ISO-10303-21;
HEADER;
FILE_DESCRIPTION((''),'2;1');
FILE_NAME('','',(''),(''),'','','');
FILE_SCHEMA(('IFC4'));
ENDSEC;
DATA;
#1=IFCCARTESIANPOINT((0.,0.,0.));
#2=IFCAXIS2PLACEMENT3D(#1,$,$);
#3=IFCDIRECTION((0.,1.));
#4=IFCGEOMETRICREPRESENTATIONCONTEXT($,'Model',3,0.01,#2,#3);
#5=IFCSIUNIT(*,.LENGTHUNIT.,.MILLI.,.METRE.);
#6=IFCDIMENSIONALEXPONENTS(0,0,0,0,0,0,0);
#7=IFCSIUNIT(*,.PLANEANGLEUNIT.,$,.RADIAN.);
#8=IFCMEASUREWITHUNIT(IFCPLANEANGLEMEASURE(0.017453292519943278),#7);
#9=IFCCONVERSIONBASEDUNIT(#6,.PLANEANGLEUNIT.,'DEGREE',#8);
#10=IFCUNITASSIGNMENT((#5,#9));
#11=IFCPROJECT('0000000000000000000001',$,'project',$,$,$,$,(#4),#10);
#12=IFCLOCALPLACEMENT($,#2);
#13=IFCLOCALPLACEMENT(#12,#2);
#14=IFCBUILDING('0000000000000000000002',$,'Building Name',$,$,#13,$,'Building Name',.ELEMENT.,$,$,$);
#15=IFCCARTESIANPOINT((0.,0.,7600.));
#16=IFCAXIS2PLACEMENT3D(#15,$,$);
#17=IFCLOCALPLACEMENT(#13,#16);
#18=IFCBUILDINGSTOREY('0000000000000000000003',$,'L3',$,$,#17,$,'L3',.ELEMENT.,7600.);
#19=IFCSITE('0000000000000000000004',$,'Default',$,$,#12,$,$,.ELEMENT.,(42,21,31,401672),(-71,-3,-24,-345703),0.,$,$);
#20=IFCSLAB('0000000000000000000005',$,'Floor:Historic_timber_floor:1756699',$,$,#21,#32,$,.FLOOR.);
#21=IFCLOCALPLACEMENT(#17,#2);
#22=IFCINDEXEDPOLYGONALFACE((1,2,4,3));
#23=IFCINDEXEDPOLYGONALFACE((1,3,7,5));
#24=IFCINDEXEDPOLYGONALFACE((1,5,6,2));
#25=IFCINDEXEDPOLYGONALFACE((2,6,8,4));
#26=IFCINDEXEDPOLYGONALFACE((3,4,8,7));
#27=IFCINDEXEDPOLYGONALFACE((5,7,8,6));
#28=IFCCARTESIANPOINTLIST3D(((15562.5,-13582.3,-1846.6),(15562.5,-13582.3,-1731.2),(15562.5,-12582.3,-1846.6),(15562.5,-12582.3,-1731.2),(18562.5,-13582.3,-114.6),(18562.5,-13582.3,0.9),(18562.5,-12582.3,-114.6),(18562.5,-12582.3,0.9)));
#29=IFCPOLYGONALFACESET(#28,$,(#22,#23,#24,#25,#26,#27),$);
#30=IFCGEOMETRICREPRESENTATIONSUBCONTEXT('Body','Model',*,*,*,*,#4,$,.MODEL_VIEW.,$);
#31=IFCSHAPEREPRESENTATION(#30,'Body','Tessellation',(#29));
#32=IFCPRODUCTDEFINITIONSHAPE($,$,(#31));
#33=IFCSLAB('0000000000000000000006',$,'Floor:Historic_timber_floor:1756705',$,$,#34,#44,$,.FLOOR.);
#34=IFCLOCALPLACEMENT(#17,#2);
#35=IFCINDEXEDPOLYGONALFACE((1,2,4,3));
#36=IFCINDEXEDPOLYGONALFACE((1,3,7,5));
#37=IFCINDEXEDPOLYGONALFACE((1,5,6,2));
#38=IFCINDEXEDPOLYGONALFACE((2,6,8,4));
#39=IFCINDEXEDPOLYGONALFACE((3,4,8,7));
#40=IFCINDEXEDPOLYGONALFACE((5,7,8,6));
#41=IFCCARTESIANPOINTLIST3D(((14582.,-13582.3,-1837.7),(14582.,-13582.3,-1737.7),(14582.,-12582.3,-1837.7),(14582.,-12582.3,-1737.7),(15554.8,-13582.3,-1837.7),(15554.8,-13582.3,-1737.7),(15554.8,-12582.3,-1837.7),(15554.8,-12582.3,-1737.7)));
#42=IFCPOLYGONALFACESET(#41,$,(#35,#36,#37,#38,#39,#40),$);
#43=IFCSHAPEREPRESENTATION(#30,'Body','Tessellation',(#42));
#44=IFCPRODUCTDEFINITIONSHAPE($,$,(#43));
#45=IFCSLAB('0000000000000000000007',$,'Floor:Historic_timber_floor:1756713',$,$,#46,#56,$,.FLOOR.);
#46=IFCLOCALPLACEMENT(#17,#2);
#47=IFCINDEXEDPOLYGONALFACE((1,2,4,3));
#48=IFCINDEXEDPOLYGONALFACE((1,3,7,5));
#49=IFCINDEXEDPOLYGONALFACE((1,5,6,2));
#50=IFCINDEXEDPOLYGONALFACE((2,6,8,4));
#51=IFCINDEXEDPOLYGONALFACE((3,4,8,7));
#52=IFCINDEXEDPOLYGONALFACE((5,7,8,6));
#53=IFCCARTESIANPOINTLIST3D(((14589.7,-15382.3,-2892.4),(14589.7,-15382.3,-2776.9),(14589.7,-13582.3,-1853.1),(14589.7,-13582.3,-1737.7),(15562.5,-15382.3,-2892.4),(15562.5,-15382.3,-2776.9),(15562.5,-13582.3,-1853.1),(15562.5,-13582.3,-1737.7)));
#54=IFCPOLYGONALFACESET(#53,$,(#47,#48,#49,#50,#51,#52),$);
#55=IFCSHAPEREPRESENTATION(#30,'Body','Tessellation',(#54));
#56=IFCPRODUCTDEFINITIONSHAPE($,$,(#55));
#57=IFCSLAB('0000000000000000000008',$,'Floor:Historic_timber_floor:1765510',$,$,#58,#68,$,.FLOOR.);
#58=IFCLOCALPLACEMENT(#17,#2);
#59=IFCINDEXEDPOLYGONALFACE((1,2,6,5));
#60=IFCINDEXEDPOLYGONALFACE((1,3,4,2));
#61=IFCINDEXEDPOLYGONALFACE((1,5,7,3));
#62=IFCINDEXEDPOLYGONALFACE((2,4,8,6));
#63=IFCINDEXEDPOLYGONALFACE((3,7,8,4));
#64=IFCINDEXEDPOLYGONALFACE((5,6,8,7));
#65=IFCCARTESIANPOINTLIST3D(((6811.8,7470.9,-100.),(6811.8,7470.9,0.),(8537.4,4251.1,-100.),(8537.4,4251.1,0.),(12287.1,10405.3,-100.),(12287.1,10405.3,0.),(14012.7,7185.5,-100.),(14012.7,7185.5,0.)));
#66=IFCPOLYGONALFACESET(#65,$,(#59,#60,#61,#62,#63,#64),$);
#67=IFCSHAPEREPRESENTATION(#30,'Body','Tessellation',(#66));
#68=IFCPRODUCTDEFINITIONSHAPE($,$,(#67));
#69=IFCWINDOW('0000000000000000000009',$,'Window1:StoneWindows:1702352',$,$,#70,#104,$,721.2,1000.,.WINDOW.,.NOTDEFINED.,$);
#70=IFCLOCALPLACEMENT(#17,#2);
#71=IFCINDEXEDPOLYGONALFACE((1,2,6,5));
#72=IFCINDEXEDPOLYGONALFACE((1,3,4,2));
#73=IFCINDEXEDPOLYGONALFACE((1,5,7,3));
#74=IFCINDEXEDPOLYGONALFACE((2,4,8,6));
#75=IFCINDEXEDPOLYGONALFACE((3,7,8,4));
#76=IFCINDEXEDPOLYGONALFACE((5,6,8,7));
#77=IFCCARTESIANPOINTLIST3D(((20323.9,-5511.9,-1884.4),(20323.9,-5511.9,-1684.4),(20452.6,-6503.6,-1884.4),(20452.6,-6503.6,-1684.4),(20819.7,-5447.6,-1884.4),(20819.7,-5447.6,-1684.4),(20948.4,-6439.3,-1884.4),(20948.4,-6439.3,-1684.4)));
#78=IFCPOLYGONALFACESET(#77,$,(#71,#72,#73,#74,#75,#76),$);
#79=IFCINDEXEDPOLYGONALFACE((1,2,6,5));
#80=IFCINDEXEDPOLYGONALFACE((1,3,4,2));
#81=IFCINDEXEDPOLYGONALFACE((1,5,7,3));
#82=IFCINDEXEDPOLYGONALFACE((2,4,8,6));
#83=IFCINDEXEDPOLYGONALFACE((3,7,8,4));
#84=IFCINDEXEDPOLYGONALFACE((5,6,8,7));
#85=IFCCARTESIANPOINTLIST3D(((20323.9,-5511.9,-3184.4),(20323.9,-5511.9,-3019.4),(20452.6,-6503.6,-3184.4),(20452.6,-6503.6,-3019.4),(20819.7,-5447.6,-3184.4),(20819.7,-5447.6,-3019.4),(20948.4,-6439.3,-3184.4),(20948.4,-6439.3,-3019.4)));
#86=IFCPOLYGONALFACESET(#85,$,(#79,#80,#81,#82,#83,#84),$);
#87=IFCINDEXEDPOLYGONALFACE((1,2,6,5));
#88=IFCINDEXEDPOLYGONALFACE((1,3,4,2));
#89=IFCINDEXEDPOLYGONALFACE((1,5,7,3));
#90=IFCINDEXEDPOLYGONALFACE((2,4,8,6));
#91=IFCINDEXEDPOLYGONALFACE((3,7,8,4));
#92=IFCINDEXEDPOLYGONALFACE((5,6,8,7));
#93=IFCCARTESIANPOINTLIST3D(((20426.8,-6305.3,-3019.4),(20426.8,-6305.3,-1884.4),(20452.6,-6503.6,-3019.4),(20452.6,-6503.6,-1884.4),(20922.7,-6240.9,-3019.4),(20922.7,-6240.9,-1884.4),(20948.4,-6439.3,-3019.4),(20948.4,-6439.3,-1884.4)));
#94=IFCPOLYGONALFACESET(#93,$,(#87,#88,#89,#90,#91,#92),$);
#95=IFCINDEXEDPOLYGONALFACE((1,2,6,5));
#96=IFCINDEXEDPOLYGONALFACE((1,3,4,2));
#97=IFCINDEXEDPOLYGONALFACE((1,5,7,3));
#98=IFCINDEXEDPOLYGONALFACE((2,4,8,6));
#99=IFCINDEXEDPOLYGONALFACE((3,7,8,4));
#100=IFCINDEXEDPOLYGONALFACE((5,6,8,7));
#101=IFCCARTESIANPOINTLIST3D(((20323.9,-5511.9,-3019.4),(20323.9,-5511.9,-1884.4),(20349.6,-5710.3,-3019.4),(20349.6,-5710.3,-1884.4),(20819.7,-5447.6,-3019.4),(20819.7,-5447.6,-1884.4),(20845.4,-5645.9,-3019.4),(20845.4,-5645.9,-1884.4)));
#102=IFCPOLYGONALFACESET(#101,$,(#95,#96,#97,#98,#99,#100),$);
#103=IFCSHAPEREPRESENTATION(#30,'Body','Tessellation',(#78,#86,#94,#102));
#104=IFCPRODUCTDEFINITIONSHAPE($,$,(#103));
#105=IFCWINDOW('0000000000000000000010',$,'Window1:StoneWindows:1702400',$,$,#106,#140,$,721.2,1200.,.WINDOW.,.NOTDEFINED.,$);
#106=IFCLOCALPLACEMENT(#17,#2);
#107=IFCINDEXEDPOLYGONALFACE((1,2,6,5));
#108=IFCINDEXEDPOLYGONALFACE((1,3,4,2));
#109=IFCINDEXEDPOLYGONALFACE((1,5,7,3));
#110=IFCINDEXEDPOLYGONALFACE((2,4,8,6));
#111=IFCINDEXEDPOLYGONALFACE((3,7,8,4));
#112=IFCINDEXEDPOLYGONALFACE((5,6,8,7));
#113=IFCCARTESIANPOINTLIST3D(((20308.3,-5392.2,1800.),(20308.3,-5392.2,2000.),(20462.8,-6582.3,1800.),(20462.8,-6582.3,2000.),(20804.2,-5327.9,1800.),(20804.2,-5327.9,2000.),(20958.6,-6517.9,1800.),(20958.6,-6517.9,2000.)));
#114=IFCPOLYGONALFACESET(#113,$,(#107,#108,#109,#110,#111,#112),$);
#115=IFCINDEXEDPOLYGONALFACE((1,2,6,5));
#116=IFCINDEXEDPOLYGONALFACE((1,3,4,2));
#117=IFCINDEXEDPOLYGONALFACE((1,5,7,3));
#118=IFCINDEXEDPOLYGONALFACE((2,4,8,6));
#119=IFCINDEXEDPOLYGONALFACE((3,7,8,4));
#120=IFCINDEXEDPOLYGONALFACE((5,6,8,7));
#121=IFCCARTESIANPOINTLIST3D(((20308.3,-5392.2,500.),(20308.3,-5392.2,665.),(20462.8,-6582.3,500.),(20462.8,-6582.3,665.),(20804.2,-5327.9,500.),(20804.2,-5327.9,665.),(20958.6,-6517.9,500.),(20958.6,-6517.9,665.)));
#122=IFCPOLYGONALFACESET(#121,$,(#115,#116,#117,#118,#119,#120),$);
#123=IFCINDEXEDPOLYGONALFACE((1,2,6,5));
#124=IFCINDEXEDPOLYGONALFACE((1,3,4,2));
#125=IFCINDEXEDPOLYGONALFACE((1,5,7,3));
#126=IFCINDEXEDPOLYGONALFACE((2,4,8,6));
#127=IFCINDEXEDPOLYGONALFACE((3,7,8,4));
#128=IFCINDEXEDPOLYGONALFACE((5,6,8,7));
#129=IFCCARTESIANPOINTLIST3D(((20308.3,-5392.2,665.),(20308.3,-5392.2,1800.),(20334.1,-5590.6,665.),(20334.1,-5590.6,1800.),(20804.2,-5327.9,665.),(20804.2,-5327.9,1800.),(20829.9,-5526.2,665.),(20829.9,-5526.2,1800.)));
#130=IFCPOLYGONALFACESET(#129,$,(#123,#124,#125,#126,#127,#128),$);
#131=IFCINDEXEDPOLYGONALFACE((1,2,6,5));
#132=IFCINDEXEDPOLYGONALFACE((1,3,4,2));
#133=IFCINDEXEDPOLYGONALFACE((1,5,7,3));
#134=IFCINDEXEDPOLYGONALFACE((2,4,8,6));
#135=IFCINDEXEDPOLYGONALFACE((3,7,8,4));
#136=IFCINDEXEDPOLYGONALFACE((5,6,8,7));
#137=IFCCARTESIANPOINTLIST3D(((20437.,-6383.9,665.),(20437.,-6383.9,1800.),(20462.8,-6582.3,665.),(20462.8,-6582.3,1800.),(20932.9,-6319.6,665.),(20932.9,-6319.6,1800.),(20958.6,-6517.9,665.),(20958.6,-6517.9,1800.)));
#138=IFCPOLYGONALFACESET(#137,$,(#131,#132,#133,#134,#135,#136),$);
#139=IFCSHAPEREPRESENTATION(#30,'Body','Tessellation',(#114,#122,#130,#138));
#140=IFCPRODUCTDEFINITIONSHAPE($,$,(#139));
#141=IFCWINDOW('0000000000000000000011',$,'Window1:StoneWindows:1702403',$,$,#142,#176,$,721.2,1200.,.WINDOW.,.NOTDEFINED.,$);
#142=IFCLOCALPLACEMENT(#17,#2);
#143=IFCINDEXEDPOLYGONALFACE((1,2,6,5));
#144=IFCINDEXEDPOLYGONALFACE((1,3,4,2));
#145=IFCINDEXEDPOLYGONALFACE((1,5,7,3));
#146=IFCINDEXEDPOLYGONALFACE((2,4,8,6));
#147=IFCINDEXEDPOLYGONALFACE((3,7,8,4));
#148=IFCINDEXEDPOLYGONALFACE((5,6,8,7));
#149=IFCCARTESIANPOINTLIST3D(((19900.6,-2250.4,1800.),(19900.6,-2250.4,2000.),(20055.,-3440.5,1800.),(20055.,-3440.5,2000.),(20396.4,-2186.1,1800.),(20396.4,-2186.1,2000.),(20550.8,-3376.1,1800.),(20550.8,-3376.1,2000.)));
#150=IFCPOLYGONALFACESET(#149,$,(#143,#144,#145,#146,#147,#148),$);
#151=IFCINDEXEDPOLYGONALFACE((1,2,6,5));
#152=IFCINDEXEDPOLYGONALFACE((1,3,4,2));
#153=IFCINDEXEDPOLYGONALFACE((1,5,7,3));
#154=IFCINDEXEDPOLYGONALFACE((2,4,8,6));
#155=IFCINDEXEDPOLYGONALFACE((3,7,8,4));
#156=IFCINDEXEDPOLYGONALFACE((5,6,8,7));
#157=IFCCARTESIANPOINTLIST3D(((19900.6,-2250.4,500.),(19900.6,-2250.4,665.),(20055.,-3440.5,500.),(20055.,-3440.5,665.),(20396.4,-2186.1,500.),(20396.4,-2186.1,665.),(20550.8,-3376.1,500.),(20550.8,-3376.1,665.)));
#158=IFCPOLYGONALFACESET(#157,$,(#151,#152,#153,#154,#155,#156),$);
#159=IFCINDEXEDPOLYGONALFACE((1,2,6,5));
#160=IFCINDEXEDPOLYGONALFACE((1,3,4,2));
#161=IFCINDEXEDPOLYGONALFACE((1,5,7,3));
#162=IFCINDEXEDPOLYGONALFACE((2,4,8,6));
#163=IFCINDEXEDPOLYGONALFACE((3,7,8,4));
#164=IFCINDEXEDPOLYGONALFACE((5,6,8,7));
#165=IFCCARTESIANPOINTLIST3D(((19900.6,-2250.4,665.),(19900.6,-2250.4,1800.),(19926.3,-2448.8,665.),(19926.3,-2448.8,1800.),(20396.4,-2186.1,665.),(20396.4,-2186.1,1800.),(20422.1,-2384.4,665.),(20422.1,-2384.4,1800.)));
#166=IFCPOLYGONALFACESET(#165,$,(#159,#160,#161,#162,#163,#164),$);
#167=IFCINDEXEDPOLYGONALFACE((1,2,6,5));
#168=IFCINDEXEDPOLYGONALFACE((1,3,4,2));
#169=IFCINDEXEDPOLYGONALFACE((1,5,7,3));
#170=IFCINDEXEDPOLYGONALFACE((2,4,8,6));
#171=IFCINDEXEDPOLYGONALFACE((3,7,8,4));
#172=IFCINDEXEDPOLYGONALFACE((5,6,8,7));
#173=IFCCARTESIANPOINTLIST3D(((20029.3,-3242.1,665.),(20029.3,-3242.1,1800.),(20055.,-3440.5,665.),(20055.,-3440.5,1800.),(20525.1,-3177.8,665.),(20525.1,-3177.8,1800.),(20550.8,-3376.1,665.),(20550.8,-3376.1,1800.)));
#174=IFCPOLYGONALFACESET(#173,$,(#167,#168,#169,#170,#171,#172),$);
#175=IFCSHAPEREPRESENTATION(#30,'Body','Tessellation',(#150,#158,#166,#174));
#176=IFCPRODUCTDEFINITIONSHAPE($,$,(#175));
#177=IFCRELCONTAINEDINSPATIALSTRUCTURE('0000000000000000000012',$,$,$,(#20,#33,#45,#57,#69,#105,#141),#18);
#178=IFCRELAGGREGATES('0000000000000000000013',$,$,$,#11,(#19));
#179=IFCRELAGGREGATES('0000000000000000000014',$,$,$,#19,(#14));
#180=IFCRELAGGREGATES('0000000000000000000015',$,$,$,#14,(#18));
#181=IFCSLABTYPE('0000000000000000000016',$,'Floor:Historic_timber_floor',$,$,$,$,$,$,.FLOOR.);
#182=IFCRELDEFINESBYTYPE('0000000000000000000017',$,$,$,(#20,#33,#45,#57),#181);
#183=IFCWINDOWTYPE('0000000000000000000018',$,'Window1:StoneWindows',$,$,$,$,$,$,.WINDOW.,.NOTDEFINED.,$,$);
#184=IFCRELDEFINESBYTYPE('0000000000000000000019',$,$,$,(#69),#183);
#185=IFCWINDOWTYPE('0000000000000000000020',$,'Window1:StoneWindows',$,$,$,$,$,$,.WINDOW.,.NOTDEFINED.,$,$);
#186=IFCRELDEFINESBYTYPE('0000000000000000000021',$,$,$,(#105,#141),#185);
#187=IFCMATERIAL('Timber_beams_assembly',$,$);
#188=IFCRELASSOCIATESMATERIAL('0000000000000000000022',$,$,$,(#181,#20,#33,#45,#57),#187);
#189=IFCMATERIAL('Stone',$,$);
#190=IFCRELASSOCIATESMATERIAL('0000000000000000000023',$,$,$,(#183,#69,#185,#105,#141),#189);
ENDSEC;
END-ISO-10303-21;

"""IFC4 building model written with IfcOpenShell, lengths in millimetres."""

from ifc_helpers import new_model, entity, si_unit, converted_unit, direction, frame, frame_2d, origin, place, context, subcontext, project, spatial, indexed_curve, rectangle, outline, extrude, source, transform, mapped, material, type_object, type_shapes, element, save


model = new_model("IFC4")

# Units and contexts
model_context = context("Model", 3, precision=0.01, world=origin(), true_north=direction((0.0, 1.0)))
body_context = subcontext(model_context, "Body", "Model", "MODEL_VIEW")
ifc_project = project(units=[si_unit("LENGTHUNIT", "METRE", prefix="MILLI"), converted_unit("PLANEANGLEUNIT", "DEGREE", entity("IfcPlaneAngleMeasure", 0.017453292519943278), si_unit("PLANEANGLEUNIT", "RADIAN"), dimensions=[0, 0, 0, 0, 0, 0, 0])], contexts=[model_context])

# Site, building, storey
site_placement = place(None, origin())
site = spatial("IfcSite", under=ifc_project, at=site_placement, Name="Default", CompositionType="ELEMENT", RefLatitude=(42, 21, 31, 401672), RefLongitude=(-71, -3, -24, -345703), RefElevation=0.0)
building_placement = place(site_placement, origin())
building = spatial("IfcBuilding", under=site, at=building_placement, Name="Building Name", LongName="Building Name", CompositionType="ELEMENT")
storey_placement = place(building_placement, frame((0.0, 0.0, 7600.0)))
storey = spatial("IfcBuildingStorey", under=building, at=storey_placement, Name="L3", LongName="L3", CompositionType="ELEMENT", Elevation=7600.0)

# Slabs
ifc_material_1 = material(Name="Timber_beams_assembly")
slab_type = type_object("IfcSlabType", Name="Floor:Historic_timber_floor", PredefinedType="FLOOR", material=ifc_material_1)
slab_1_placement = place(storey_placement, frame((15562.5, -13582.3, -1846.6)))
element("IfcSlab", 1, at=slab_1_placement, inside=storey, type_object=slab_type, material=ifc_material_1, Name="Floor:Historic_timber_floor:1756699", PredefinedType="FLOOR", context=body_context, shape_type="SweptSolid", body=[
    extrude(rectangle(XDim=1000.0, YDim=3464.1, at=frame_2d((-1732.1, -500.0), x_axis=(0.0, -1.0))), frame((3000.0, 1000.0, 1847.5), z_axis=(-0.5, 0.0, 0.866025), x_axis=(0.866025, 0.0, 0.5)), (-0.5, 0.0, -0.866025), 115.5),
])
slab_2_placement = place(storey_placement, origin())
element("IfcSlab", 2, at=slab_2_placement, inside=storey, type_object=slab_type, material=ifc_material_1, Name="Floor:Historic_timber_floor:1756705", PredefinedType="FLOOR", context=body_context, shape_type="SweptSolid", body=[
    extrude(outline(indexed_curve([(-500.0, -486.4), (500.0, -486.4), (500.0, 486.4), (-500.0, 486.4), (-500.0, -486.4)], self_intersect=False)), frame((15068.4, -13082.3, -1737.7), z_axis=(0.0, 0.0, -1.0), x_axis=(0.0, 1.0, 0.0)), (0.0, 0.0, 1.0), 100.0),
])
slab_3_placement = place(storey_placement, frame((14589.7, -15382.3, -2892.4)))
element("IfcSlab", 3, at=slab_3_placement, inside=storey, type_object=slab_type, material=ifc_material_1, Name="Floor:Historic_timber_floor:1756713", PredefinedType="FLOOR", context=body_context, shape_type="SweptSolid", body=[
    extrude(rectangle(XDim=972.8, YDim=2078.5, at=frame_2d((486.4, -1039.2), x_axis=(1.0, 0.0))), frame((0.0, 1800.0, 1154.7), z_axis=(0.0, -0.5, 0.866025), x_axis=(1.0, 0.0, 0.0)), (0.0, -0.5, -0.866025), 115.5),
])
slab_4_placement = place(storey_placement, origin())
element("IfcSlab", 4, at=slab_4_placement, inside=storey, type_object=slab_type, material=ifc_material_1, Name="Floor:Historic_timber_floor:1765510", PredefinedType="FLOOR", context=body_context, shape_type="SweptSolid", body=[
    extrude(outline(indexed_curve([(-1826.5, -3106.0), (1826.5, -3106.0), (1826.5, 3106.0), (-1826.5, 3106.0), (-1826.5, -3106.0)], self_intersect=False)), frame((10412.3, 7328.2, 0.0), z_axis=(0.0, 0.0, -1.0), x_axis=(0.472369, -0.881401, 0.0)), (0.0, 0.0, 1.0), 100.0),
])

# Windows
ifc_material_2 = material(Name="Stone")
window_type_1 = type_object("IfcWindowType", Name="Window1:StoneWindows", PartitioningType="NOTDEFINED", PredefinedType="WINDOW", material=ifc_material_2)
shared_shape_1 = source(origin(), body_context, "Body", "SweptSolid", [
    extrude(outline(indexed_curve([(-250.0, -500.0), (250.0, -500.0), (250.0, 500.0), (-250.0, 500.0), (-250.0, -500.0)], self_intersect=False)), frame((0.0, 0.0, 2100.0), z_axis=(0.0, 0.0, 1.0), x_axis=(0.0, 1.0, 0.0)), (0.0, 0.0, 1.0), 200.0),
    extrude(outline(indexed_curve([(-250.0, -500.0), (250.0, -500.0), (250.0, 500.0), (-250.0, 500.0), (-250.0, -500.0)], self_intersect=False)), frame((0.0, 0.0, 800.0), z_axis=(0.0, 0.0, 1.0), x_axis=(0.0, 1.0, 0.0)), (0.0, 0.0, 1.0), 165.0),
    extrude(outline(indexed_curve([(-250.0, -100.0), (250.0, -100.0), (250.0, 100.0), (-250.0, 100.0), (-250.0, -100.0)], self_intersect=False)), frame((-400.0, 0.0, 965.0), z_axis=(0.0, 0.0, 1.0), x_axis=(0.0, 1.0, 0.0)), (0.0, 0.0, 1.0), 1135.0),
    extrude(outline(indexed_curve([(-250.0, -100.0), (250.0, -100.0), (250.0, 100.0), (-250.0, 100.0), (-250.0, -100.0)], self_intersect=False)), frame((400.0, 0.0, 965.0), z_axis=(0.0, 0.0, 1.0), x_axis=(0.0, 1.0, 0.0)), (0.0, 0.0, 1.0), 1135.0),
])
type_shapes(window_type_1, [shared_shape_1])
window_placement = place(storey_placement, frame((20636.1, -5975.6, -3984.4), z_axis=(0.0, 0.0, 1.0), x_axis=(-0.128709, 0.991682, 0.0)))
element("IfcWindow", 5, at=window_placement, inside=storey, type_object=window_type_1, material=ifc_material_2, Name="Window1:StoneWindows:1702352", OverallHeight=721.2, OverallWidth=1000.0, PartitioningType="NOTDEFINED", PredefinedType="WINDOW", context=body_context, shape_type="MappedRepresentation", body=[
    mapped(shared_shape_1, transform((0.0, 0.0, 0.0), scale=1.0)),
])
window_type_2 = type_object("IfcWindowType", Name="Window1:StoneWindows", PartitioningType="NOTDEFINED", PredefinedType="WINDOW", material=ifc_material_2)
shared_shape_2 = source(origin(), body_context, "Body", "SweptSolid", [
    extrude(outline(indexed_curve([(-250.0, -600.0), (250.0, -600.0), (250.0, 600.0), (-250.0, 600.0), (-250.0, -600.0)], self_intersect=False)), frame((0.0, 0.0, 2100.0), z_axis=(0.0, 0.0, 1.0), x_axis=(0.0, 1.0, 0.0)), (0.0, 0.0, 1.0), 200.0),
    extrude(outline(indexed_curve([(-250.0, -600.0), (250.0, -600.0), (250.0, 600.0), (-250.0, 600.0), (-250.0, -600.0)], self_intersect=False)), frame((0.0, 0.0, 800.0), z_axis=(0.0, 0.0, 1.0), x_axis=(0.0, 1.0, 0.0)), (0.0, 0.0, 1.0), 165.0),
    extrude(outline(indexed_curve([(-250.0, -100.0), (250.0, -100.0), (250.0, 100.0), (-250.0, 100.0), (-250.0, -100.0)], self_intersect=False)), frame((-500.0, 0.0, 965.0), z_axis=(0.0, 0.0, 1.0), x_axis=(0.0, 1.0, 0.0)), (0.0, 0.0, 1.0), 1135.0),
    extrude(outline(indexed_curve([(-250.0, -100.0), (250.0, -100.0), (250.0, 100.0), (-250.0, 100.0), (-250.0, -100.0)], self_intersect=False)), frame((500.0, 0.0, 965.0), z_axis=(0.0, 0.0, 1.0), x_axis=(0.0, 1.0, 0.0)), (0.0, 0.0, 1.0), 1135.0),
])
type_shapes(window_type_2, [shared_shape_2])
for number, where, z_axis, x_axis, name in (
    (6, (20633.5, -5955.1, -300.0), (0.0, 0.0, 1.0), (0.128709, -0.991682, 0.0), "Window1:StoneWindows:1702400"),
    (7, (20225.7, -2813.3, -300.0), (0.0, 0.0, 1.0), (0.128709, -0.991682, 0.0), "Window1:StoneWindows:1702403"),
):
    element("IfcWindow", number, at=place(storey_placement, frame(where, z_axis=z_axis, x_axis=x_axis)), inside=storey, type_object=window_type_2, material=ifc_material_2, Name=name, OverallHeight=721.2, OverallWidth=1200.0, PartitioningType="NOTDEFINED", PredefinedType="WINDOW", context=body_context, shape_type="MappedRepresentation", body=[
        mapped(shared_shape_2, transform((0.0, 0.0, 0.0), scale=1.0)),
    ])

save(model, "model.ifc")
